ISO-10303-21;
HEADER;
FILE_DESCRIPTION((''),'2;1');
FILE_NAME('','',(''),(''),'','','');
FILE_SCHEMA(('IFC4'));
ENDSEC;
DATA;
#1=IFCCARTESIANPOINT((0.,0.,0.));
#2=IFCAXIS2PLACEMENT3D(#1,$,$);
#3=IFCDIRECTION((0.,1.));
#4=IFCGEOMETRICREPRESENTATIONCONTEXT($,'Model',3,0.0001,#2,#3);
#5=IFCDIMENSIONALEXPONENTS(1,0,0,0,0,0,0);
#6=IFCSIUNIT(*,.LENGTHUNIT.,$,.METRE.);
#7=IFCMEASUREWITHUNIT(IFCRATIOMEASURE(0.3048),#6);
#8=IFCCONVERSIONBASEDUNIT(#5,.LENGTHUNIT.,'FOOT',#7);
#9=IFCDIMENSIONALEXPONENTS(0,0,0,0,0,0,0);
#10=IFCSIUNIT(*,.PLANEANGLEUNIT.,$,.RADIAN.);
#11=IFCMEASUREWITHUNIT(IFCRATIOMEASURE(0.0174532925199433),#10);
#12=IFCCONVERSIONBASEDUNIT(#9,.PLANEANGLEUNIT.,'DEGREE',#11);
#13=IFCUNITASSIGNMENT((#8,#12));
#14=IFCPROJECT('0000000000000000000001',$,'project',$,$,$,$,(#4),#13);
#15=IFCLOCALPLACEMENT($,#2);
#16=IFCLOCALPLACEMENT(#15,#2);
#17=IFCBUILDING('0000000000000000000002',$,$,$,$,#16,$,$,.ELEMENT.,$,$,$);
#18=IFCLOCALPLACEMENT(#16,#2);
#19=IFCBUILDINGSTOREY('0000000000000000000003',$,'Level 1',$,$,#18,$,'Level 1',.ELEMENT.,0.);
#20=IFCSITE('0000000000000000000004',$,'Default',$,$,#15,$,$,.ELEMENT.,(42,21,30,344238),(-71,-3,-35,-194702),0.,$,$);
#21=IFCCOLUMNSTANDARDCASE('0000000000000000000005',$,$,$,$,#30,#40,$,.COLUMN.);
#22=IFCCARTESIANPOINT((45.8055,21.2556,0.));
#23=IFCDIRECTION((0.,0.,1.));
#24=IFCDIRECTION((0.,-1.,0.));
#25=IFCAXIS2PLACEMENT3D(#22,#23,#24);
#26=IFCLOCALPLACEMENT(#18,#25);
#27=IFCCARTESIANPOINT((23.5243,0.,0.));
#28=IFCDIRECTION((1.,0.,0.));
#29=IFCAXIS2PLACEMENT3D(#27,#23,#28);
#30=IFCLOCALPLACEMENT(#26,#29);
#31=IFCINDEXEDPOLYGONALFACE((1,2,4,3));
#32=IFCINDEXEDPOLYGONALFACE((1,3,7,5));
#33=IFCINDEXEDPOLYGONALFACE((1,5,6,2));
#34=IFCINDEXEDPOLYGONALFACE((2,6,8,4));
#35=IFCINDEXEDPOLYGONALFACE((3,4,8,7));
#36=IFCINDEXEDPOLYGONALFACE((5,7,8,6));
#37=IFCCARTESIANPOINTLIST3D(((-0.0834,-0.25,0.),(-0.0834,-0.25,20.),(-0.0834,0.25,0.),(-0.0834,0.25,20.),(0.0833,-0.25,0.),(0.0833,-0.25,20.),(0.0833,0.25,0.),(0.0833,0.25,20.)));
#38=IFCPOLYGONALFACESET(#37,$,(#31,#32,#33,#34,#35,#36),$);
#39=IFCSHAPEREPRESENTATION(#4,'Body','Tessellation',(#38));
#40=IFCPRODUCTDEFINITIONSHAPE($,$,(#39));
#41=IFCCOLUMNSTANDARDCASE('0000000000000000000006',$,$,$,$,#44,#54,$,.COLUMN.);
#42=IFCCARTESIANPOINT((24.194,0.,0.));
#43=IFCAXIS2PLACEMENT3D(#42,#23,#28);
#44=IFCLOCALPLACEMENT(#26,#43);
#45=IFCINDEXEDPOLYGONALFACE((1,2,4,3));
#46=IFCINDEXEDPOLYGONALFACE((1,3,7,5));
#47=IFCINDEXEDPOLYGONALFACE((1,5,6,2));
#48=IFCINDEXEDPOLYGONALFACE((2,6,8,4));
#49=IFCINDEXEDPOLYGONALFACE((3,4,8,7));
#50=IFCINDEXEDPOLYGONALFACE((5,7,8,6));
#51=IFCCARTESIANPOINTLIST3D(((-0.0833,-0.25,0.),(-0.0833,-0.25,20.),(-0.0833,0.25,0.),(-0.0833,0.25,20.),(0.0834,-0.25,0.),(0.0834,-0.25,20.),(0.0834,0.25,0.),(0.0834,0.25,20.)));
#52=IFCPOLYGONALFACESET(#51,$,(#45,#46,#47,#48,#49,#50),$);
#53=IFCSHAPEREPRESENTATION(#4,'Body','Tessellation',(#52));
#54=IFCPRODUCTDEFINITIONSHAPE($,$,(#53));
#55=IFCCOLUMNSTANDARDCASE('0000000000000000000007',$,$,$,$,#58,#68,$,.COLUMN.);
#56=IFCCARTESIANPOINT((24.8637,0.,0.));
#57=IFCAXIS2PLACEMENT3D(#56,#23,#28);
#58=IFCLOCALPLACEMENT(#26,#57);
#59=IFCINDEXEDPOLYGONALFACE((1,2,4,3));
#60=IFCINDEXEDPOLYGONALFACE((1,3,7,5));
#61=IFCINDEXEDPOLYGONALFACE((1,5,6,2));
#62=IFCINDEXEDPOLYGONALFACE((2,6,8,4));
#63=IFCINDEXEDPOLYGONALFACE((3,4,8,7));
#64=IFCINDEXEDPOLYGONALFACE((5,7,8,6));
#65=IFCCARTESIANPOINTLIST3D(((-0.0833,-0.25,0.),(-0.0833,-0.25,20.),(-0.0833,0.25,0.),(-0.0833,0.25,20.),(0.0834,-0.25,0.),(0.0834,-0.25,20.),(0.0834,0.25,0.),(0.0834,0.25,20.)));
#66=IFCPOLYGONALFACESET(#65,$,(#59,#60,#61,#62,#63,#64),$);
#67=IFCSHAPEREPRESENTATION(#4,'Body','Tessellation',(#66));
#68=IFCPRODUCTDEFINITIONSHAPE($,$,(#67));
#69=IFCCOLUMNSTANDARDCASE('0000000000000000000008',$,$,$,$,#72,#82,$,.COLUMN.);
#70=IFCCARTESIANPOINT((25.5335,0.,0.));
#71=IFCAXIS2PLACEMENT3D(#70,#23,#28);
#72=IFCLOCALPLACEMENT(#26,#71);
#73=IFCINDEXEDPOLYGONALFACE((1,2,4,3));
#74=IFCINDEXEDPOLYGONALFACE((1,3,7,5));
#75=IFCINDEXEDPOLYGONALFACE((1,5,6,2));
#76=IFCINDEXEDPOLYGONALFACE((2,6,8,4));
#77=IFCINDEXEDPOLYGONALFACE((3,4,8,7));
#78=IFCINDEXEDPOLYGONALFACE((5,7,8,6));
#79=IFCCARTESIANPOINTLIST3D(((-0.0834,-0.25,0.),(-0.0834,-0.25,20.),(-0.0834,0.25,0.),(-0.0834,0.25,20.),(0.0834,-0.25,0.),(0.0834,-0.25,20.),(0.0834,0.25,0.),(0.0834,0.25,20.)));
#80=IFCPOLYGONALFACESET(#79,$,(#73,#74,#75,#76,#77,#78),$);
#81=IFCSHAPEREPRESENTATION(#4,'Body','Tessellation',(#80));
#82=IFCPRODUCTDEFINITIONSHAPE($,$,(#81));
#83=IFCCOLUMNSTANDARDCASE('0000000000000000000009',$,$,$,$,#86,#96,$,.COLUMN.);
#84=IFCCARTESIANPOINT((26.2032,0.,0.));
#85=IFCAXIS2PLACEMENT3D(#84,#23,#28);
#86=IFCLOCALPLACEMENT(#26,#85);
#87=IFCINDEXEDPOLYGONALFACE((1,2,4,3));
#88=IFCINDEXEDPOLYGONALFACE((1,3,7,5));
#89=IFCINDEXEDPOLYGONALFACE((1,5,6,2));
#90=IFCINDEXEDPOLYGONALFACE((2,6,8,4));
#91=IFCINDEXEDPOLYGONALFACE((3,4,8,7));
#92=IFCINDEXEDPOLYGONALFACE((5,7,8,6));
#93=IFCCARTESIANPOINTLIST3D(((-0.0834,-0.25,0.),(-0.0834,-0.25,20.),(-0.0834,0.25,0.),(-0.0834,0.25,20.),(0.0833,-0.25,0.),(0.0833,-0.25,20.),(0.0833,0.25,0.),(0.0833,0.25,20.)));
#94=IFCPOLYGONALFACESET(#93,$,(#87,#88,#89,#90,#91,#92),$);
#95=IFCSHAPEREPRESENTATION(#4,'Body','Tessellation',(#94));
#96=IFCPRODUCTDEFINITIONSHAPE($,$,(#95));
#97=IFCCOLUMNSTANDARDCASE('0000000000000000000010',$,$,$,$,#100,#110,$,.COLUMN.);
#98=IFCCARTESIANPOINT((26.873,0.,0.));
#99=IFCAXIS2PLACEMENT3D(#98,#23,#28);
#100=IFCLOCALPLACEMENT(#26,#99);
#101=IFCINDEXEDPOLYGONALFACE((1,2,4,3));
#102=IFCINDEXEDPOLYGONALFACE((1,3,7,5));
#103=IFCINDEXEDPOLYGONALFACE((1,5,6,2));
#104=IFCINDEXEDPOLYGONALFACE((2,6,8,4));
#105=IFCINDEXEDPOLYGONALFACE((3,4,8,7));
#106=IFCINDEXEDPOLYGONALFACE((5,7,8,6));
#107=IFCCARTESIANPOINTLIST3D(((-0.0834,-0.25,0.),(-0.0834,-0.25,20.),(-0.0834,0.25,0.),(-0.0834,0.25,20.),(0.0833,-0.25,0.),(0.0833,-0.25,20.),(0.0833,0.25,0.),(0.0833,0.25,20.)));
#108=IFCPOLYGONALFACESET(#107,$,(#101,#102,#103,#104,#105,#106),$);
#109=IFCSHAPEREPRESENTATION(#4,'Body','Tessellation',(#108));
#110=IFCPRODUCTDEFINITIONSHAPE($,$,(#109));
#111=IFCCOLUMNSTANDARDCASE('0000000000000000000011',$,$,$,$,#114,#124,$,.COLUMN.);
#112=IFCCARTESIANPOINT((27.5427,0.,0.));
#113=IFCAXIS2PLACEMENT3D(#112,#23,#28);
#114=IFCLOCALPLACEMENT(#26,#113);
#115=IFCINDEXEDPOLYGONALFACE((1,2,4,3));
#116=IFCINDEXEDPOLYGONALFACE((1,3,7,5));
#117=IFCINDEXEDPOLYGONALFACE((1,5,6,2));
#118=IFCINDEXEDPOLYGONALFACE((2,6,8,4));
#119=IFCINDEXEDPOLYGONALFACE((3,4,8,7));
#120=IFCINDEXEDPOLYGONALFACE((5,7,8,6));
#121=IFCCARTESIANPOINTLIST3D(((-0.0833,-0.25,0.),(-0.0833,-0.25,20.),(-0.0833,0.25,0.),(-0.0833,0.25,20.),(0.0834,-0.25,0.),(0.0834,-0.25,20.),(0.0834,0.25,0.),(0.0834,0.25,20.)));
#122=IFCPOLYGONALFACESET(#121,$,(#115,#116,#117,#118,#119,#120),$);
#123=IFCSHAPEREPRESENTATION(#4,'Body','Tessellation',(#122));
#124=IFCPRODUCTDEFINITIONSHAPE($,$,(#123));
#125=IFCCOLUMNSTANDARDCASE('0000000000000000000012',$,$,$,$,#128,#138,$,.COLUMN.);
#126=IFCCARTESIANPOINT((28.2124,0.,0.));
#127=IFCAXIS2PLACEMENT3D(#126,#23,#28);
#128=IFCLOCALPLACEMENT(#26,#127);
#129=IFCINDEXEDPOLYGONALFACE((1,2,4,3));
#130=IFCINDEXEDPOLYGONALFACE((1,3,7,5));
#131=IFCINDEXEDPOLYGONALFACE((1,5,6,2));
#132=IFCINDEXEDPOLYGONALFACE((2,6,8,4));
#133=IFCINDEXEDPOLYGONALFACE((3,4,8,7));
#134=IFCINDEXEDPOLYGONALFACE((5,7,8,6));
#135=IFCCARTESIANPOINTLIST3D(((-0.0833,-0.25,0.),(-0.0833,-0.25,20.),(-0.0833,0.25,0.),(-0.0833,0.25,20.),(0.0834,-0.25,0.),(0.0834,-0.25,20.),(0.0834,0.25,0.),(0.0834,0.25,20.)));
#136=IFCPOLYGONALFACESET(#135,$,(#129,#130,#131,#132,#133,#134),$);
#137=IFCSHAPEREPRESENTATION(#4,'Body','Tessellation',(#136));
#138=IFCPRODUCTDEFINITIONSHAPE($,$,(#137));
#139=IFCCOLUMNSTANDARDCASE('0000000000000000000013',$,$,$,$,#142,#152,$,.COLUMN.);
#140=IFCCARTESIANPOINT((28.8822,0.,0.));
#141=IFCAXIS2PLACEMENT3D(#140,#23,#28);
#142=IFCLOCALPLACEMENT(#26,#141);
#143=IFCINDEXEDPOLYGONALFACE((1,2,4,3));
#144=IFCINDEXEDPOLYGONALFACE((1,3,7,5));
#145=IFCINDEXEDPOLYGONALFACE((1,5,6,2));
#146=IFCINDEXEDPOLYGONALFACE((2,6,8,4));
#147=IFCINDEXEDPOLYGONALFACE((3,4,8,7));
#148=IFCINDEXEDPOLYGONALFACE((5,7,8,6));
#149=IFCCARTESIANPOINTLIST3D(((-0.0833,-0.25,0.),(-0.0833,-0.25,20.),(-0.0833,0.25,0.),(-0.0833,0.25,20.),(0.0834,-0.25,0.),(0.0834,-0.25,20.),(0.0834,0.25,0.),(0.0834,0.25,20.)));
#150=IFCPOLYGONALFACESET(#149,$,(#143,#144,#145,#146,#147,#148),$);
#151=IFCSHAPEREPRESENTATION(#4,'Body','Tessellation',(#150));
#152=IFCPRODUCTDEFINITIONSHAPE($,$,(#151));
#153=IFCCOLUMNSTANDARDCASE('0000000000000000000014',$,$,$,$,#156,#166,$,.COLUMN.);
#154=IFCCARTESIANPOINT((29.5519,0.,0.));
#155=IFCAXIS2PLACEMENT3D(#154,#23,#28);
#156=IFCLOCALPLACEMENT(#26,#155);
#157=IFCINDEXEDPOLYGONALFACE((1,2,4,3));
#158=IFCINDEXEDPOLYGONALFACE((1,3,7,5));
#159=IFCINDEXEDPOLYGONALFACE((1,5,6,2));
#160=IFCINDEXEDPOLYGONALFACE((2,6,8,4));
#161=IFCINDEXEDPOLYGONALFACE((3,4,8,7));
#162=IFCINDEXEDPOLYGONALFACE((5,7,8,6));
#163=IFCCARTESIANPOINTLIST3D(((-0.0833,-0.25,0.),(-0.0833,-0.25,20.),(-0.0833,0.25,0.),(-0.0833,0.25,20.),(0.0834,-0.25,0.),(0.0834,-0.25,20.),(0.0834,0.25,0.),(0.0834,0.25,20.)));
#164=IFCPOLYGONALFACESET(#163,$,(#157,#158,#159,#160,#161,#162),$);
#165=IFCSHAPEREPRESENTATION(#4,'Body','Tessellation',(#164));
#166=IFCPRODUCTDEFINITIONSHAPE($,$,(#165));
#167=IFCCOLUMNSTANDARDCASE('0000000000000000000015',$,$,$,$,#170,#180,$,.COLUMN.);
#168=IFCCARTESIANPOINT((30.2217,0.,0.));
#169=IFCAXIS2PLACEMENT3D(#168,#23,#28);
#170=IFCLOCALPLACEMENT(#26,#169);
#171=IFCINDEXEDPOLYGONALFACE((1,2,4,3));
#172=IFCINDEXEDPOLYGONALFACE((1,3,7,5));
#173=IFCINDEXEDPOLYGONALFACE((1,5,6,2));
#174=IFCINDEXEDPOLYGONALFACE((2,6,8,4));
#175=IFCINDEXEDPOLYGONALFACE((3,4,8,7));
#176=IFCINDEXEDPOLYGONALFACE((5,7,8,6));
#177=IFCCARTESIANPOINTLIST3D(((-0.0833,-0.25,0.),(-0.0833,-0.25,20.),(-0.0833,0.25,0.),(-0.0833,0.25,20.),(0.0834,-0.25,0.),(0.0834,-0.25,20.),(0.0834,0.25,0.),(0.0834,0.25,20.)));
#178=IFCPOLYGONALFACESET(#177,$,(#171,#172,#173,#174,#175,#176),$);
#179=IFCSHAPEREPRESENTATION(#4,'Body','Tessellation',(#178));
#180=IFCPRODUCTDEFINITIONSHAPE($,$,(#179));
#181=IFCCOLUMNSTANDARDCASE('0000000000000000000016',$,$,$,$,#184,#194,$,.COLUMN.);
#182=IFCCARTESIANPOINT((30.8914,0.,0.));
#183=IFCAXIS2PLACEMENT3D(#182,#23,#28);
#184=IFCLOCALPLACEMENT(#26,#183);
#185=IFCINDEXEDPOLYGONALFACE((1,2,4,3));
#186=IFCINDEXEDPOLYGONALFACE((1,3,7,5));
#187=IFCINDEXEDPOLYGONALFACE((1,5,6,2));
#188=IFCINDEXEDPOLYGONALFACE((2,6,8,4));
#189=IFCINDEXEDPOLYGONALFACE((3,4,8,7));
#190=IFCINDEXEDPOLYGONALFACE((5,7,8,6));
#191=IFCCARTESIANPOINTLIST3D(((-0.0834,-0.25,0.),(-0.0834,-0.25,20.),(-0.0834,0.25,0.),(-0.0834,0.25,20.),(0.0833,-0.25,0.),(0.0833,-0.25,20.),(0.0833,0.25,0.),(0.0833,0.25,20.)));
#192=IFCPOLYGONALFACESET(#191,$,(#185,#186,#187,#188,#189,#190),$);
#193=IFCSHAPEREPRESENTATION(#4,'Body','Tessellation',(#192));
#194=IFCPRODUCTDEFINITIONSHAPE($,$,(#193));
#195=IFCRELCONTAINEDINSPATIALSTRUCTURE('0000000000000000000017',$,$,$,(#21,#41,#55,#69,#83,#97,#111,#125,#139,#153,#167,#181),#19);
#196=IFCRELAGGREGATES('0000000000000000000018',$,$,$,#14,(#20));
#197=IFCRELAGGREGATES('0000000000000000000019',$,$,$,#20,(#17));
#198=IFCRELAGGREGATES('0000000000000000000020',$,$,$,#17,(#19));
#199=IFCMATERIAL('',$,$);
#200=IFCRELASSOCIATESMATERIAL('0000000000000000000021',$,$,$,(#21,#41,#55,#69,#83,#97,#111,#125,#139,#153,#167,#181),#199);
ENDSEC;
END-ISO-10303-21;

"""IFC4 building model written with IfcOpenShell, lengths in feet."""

from ifc_helpers import new_model, entity, si_unit, converted_unit, direction, frame, origin, place, context, project, spatial, rectangle, extrude, material, element, save


model = new_model("IFC4")

# Units and contexts
model_context = context("Model", 3, precision=0.0001, world=origin(), true_north=direction((0.0, 1.0)))
ifc_project = project(units=[converted_unit("LENGTHUNIT", "FOOT", entity("IfcRatioMeasure", 0.3048), si_unit("LENGTHUNIT", "METRE"), dimensions=[1, 0, 0, 0, 0, 0, 0]), converted_unit("PLANEANGLEUNIT", "DEGREE", entity("IfcRatioMeasure", 0.0174532925199433), si_unit("PLANEANGLEUNIT", "RADIAN"), dimensions=[0, 0, 0, 0, 0, 0, 0])], contexts=[model_context])

# Site, building, storey
site_placement = place(None, origin())
site = spatial("IfcSite", under=ifc_project, at=site_placement, Name="Default", CompositionType="ELEMENT", RefLatitude=(42, 21, 30, 344238), RefLongitude=(-71, -3, -35, -194702), RefElevation=0.0)
building_placement = place(site_placement, origin())
building = spatial("IfcBuilding", under=site, at=building_placement, CompositionType="ELEMENT")
storey_placement = place(building_placement, origin())
storey = spatial("IfcBuildingStorey", under=building, at=storey_placement, Name="Level 1", LongName="Level 1", CompositionType="ELEMENT", Elevation=0.0)

# Columns
ifc_material_1 = material(Name="")
placement = place(storey_placement, frame((45.8055, 21.2556, 0.0), z_axis=(0.0, 0.0, 1.0), x_axis=(0.0, -1.0, 0.0)))
for number, where, z_axis, x_axis in (
    (1, (23.5243, 0.0, 0.0), (0.0, 0.0, 1.0), (1.0, 0.0, 0.0)),
    (2, (24.194, 0.0, 0.0), (0.0, 0.0, 1.0), (1.0, 0.0, 0.0)),
    (3, (24.8637, 0.0, 0.0), (0.0, 0.0, 1.0), (1.0, 0.0, 0.0)),
    (4, (25.5335, 0.0, 0.0), (0.0, 0.0, 1.0), (1.0, 0.0, 0.0)),
    (5, (26.2032, 0.0, 0.0), (0.0, 0.0, 1.0), (1.0, 0.0, 0.0)),
    (6, (26.873, 0.0, 0.0), (0.0, 0.0, 1.0), (1.0, 0.0, 0.0)),
    (7, (27.5427, 0.0, 0.0), (0.0, 0.0, 1.0), (1.0, 0.0, 0.0)),
    (8, (28.2124, 0.0, 0.0), (0.0, 0.0, 1.0), (1.0, 0.0, 0.0)),
    (9, (28.8822, 0.0, 0.0), (0.0, 0.0, 1.0), (1.0, 0.0, 0.0)),
    (10, (29.5519, 0.0, 0.0), (0.0, 0.0, 1.0), (1.0, 0.0, 0.0)),
    (11, (30.2217, 0.0, 0.0), (0.0, 0.0, 1.0), (1.0, 0.0, 0.0)),
    (12, (30.8914, 0.0, 0.0), (0.0, 0.0, 1.0), (1.0, 0.0, 0.0)),
):
    element("IfcColumnStandardCase", number, at=place(placement, frame(where, z_axis=z_axis, x_axis=x_axis)), inside=storey, material=ifc_material_1, PredefinedType="COLUMN", context=model_context, shape_type="SweptSolid", body=[
        extrude(rectangle(XDim=0.1667, YDim=0.5), origin(), (0.0, 0.0, 1.0), 20.0),
    ])

save(model, "model.ifc")
